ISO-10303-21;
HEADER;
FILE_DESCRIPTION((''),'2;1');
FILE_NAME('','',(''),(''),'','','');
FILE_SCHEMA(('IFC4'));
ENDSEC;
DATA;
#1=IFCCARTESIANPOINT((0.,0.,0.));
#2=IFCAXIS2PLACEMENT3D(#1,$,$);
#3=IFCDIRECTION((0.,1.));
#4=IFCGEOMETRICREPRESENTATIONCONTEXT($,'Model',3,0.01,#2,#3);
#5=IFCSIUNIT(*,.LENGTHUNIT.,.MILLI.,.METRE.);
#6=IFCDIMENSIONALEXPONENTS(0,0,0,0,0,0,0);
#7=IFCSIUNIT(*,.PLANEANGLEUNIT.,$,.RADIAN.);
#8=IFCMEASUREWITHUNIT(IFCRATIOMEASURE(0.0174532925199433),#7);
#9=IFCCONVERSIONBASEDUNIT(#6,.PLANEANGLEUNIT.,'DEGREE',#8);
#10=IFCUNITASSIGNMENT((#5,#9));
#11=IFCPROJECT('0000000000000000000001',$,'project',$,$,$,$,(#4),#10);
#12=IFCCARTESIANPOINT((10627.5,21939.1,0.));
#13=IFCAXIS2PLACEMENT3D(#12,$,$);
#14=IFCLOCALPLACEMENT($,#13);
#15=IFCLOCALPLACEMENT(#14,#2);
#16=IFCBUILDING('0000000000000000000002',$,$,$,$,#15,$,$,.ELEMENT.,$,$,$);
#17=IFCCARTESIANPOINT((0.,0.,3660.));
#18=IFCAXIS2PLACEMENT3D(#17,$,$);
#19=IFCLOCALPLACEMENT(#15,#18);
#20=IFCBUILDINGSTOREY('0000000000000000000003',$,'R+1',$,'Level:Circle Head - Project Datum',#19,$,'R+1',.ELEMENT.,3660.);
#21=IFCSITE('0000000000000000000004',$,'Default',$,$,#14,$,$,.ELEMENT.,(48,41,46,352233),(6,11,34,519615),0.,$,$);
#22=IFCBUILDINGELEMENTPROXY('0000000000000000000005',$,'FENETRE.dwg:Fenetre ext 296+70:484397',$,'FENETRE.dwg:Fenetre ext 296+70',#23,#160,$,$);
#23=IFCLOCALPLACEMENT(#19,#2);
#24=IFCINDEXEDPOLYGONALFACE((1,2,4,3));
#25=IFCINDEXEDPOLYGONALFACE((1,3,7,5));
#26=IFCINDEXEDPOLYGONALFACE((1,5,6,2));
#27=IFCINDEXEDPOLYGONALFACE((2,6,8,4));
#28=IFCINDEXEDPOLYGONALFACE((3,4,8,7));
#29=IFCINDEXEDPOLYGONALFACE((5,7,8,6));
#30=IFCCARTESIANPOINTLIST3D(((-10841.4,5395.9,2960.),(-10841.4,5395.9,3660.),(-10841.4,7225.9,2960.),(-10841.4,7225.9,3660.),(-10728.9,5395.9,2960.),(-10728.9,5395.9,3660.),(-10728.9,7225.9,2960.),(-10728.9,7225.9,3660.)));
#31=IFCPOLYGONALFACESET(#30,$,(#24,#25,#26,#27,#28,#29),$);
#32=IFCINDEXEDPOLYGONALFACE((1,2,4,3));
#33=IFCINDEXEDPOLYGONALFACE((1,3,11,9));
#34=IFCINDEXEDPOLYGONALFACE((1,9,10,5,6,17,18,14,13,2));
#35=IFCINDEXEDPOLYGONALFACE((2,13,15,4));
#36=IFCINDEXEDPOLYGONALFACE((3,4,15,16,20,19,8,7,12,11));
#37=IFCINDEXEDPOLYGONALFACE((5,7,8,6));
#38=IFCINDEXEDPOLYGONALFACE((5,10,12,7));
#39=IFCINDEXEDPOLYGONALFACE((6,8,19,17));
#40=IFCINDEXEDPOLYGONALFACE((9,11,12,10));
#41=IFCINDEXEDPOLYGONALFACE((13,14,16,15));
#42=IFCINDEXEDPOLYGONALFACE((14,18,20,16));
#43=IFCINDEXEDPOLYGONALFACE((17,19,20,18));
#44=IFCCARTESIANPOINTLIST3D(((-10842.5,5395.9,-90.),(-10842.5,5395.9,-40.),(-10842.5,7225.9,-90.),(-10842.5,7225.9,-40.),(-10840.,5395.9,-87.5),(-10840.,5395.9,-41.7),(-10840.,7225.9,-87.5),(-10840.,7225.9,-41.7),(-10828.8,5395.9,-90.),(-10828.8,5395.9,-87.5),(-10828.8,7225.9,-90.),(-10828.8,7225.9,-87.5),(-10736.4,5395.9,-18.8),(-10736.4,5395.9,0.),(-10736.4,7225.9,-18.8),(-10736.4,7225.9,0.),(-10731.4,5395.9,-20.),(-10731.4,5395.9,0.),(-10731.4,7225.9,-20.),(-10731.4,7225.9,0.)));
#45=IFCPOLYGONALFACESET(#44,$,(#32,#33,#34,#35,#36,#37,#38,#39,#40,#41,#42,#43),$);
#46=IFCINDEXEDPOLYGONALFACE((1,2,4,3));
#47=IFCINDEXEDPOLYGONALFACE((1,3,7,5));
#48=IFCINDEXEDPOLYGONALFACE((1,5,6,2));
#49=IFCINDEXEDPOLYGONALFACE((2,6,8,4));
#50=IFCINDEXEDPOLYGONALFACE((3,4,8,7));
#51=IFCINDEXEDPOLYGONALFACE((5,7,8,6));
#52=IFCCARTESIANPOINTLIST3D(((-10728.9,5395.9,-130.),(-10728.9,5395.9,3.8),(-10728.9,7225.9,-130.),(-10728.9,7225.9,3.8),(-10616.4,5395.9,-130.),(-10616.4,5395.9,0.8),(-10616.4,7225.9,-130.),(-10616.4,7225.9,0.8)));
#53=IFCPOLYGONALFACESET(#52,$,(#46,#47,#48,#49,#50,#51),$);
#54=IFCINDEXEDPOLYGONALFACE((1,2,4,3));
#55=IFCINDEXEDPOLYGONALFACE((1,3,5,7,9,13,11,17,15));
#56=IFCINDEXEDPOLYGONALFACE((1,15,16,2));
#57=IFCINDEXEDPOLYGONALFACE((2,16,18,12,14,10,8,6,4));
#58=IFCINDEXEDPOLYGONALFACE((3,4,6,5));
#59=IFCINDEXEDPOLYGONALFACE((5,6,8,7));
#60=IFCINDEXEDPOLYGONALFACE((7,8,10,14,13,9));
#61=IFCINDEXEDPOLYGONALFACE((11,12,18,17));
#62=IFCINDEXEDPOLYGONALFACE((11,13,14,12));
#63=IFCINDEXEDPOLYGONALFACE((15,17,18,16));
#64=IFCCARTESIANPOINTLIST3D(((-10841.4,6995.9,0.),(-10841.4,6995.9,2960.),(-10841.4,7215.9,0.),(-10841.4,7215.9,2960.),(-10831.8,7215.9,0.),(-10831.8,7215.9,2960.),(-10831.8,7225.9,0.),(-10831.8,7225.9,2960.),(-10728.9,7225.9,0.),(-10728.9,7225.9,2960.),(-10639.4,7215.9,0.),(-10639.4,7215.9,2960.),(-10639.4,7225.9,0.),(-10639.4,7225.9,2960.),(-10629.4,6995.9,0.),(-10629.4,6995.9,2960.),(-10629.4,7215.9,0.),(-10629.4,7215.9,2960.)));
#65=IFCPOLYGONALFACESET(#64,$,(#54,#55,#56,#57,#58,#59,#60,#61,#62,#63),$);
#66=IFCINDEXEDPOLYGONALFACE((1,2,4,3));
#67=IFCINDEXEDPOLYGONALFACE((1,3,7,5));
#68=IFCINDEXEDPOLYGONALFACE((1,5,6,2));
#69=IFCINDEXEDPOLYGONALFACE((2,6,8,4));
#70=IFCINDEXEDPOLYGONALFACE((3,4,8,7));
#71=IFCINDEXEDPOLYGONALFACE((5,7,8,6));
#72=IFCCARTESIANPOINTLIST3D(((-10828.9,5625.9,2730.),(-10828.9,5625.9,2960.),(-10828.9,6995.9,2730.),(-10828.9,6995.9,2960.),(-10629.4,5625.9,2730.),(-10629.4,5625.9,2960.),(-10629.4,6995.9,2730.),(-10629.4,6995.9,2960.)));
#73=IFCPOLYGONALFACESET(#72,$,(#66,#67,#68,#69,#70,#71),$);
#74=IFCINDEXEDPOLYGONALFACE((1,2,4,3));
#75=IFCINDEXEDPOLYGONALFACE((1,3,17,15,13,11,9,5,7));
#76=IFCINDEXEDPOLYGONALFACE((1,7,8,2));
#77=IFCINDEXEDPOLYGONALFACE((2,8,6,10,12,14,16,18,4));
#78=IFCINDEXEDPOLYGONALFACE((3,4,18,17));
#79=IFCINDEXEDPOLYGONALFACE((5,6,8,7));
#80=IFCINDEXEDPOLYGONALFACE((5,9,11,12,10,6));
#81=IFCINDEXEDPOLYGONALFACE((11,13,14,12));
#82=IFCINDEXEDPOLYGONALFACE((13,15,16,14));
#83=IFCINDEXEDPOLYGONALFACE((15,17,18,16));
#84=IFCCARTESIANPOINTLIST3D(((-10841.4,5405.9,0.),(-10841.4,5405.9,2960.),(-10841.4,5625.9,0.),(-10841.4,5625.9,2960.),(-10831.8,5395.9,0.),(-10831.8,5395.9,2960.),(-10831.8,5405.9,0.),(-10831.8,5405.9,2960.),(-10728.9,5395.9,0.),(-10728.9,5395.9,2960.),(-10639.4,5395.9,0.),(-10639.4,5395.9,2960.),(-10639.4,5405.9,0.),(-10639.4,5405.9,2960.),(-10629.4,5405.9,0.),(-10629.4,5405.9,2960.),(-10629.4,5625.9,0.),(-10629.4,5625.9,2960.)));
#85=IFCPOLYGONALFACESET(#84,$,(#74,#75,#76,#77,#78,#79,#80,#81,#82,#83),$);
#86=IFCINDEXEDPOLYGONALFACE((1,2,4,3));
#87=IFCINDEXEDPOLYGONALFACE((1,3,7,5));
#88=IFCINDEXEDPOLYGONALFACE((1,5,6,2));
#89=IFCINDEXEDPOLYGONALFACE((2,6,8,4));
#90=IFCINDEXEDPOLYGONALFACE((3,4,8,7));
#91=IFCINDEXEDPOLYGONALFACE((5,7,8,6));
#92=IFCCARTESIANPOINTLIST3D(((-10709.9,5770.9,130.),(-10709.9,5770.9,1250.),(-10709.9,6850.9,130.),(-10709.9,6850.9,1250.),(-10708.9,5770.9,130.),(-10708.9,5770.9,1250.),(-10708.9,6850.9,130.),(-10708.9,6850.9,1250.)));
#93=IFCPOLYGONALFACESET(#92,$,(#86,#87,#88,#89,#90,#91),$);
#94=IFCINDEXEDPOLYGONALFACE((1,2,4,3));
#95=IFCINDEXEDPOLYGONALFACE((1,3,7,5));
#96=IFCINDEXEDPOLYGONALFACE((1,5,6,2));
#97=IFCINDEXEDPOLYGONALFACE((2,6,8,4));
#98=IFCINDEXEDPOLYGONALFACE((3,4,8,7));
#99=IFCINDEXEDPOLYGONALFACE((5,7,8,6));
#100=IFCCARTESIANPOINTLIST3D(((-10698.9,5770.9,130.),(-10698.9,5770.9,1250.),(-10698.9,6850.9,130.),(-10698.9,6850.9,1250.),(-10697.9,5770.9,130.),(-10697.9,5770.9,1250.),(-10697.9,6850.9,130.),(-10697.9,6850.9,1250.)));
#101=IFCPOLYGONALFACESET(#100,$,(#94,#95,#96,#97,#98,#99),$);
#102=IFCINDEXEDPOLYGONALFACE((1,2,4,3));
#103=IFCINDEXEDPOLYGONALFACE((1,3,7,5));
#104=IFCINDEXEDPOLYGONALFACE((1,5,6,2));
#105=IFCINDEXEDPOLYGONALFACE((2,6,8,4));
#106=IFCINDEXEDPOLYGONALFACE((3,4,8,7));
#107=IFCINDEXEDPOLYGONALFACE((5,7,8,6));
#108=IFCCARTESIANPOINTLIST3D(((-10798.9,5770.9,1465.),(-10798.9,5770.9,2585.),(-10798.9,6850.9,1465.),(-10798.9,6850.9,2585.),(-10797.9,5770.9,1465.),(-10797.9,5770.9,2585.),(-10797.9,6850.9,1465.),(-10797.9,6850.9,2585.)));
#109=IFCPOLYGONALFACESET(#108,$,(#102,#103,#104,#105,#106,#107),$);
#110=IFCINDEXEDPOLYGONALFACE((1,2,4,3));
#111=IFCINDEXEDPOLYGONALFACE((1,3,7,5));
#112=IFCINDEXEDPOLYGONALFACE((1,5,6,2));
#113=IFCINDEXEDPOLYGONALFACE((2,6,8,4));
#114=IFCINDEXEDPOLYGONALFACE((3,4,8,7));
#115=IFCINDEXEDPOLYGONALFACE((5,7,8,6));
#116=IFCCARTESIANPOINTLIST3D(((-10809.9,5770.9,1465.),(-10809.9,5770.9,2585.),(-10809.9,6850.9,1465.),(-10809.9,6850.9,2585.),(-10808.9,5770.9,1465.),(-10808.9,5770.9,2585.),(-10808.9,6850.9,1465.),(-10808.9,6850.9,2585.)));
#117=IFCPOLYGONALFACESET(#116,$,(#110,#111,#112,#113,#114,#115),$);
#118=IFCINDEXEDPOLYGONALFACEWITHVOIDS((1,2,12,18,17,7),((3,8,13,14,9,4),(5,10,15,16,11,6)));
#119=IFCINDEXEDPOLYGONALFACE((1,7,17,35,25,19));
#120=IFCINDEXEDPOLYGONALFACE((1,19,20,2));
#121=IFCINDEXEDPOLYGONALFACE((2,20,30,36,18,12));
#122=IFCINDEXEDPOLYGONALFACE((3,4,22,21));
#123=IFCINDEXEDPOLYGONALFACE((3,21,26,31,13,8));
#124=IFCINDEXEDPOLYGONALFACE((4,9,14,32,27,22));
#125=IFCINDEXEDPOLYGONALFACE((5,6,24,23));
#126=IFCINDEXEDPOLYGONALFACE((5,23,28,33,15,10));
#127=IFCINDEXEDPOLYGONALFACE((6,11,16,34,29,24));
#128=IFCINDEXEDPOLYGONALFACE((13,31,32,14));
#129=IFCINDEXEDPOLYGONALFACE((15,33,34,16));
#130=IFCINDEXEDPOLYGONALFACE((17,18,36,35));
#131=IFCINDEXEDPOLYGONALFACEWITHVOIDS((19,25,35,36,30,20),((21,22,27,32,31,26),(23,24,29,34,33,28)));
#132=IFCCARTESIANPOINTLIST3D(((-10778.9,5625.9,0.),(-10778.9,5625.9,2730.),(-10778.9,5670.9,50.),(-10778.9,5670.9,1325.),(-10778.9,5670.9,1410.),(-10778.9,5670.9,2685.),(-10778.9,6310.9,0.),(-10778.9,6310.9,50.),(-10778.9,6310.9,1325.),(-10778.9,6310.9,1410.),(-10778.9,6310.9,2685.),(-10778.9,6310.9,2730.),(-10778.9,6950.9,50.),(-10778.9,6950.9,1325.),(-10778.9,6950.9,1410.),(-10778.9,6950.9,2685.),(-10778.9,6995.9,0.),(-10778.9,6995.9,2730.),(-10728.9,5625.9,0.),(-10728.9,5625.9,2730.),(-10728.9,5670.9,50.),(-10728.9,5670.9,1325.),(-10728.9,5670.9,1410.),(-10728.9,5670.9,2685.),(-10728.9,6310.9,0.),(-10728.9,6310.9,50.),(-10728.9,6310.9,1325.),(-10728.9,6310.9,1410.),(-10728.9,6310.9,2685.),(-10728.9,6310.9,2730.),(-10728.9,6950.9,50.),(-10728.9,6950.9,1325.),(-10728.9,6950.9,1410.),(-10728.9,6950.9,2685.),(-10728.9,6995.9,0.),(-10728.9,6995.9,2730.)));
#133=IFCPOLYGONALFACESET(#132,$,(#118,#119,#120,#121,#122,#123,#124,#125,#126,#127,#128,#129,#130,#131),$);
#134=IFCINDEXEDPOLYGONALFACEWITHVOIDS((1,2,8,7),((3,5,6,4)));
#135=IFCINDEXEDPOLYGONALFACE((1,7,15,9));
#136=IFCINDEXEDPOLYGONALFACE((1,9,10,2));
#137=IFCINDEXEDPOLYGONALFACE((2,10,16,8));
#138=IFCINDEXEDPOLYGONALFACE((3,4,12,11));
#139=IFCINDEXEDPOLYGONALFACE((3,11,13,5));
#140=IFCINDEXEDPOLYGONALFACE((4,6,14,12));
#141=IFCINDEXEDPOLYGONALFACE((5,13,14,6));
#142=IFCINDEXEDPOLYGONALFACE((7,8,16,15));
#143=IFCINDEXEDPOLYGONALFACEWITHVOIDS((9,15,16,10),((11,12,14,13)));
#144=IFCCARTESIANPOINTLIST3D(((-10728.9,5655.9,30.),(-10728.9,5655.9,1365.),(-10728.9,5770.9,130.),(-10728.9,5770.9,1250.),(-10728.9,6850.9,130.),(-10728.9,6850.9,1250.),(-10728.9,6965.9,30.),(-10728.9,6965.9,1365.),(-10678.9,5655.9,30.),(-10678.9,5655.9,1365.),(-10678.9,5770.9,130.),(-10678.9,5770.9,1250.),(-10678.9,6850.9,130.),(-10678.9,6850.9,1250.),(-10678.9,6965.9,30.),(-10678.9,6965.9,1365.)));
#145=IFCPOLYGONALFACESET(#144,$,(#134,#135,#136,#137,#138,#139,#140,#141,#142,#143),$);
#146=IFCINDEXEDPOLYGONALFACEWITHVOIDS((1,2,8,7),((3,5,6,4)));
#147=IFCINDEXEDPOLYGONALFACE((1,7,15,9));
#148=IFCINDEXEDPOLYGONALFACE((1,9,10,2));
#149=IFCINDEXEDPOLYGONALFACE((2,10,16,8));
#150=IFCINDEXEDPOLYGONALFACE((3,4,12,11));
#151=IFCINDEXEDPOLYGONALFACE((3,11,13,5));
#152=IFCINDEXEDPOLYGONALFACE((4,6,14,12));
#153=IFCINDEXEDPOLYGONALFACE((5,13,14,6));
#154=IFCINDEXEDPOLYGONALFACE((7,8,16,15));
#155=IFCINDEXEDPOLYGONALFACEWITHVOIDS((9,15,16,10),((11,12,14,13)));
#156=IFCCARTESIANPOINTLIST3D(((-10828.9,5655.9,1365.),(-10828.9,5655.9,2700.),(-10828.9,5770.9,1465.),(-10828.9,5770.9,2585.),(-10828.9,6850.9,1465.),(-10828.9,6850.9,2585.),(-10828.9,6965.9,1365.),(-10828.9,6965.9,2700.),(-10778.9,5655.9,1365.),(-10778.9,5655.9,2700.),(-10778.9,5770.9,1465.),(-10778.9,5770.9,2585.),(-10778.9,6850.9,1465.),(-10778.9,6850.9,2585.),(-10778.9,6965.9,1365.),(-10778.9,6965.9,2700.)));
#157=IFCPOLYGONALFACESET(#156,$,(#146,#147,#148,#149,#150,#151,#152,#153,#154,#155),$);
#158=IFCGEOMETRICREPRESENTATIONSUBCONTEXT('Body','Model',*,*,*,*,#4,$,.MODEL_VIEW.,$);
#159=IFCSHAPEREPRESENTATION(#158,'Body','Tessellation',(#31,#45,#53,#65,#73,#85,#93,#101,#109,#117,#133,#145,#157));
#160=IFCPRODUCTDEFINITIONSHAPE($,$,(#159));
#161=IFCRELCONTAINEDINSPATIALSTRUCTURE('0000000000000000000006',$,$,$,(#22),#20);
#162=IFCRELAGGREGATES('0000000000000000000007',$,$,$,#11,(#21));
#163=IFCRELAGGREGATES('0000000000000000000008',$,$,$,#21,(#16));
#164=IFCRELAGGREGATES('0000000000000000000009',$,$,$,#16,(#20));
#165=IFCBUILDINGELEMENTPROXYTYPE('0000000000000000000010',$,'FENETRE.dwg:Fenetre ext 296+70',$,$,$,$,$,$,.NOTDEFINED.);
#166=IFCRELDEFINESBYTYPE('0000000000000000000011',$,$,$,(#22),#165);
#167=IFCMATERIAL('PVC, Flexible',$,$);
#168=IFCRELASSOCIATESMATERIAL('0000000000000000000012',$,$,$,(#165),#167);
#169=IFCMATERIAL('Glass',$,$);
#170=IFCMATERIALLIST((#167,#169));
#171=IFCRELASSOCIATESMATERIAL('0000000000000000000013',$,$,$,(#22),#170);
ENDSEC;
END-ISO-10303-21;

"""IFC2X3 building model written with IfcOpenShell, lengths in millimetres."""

from ifc_helpers import new_model, entity, si_unit, converted_unit, direction, frame, frame_2d, origin, origin_2d_with_axis, place, context, subcontext, project, spatial, polyline, rectangle, outline, extrude, source, transform, mapped, material, material_list, type_object, type_shapes, element, save


model = new_model("IFC2X3")

# Units and contexts
model_context = context("Model", 3, precision=0.01, world=origin(), true_north=direction((0.0, 1.0)))
body_context = subcontext(model_context, "Body", "Model", "MODEL_VIEW")
ifc_project = project(units=[si_unit("LENGTHUNIT", "METRE", prefix="MILLI"), converted_unit("PLANEANGLEUNIT", "DEGREE", entity("IfcRatioMeasure", 0.0174532925199433), si_unit("PLANEANGLEUNIT", "RADIAN"), dimensions=[0, 0, 0, 0, 0, 0, 0])], contexts=[model_context])

# Site, building, storey
site_placement = place(None, frame((10627.5, 21939.1, 0.0)))
site = spatial("IfcSite", under=ifc_project, at=site_placement, Name="Default", CompositionType="ELEMENT", RefLatitude=(48, 41, 46, 352233), RefLongitude=(6, 11, 34, 519615), RefElevation=0.0)
building_placement = place(site_placement, origin())
building = spatial("IfcBuilding", under=site, at=building_placement, CompositionType="ELEMENT")
storey_placement = place(building_placement, frame((0.0, 0.0, 3660.0)))
storey = spatial("IfcBuildingStorey", under=building, at=storey_placement, Name="R+1", ObjectType="Level:Circle Head - Project Datum", LongName="R+1", CompositionType="ELEMENT", Elevation=3660.0)

# Building element proxy
ifc_material_1 = material(Name="PVC, Flexible")
ifc_material_2 = material(Name="Glass")
building_element_proxy_type_1 = type_object("IfcBuildingElementProxyType", Name="FENETRE.dwg:Fenetre ext 296+70", PredefinedType="NOTDEFINED", material=ifc_material_1)
shared_shape_1 = source(origin(), body_context, "Body", "SweptSolid", [
    extrude(rectangle(XDim=1830.0, YDim=112.5, at=origin_2d_with_axis()), frame((-10.4, 56.3, 2960.0), z_axis=(0.0, 0.0, 1.0), x_axis=(-1.0, 0.0, 0.0)), (0.0, 0.0, 1.0), 700.0),
    extrude(outline(polyline([(-68.6, -14.4), (-72.5, -34.0), (-67.6, -35.0), (-63.9, -16.6), (44.3, -16.6), (54.1, 32.5), (40.6, 35.2), (40.1, 32.7), (51.2, 30.5), (42.2, -14.4), (-68.6, -14.4)])), frame((-925.4, 66.9, -47.5), z_axis=(-1.0, 0.0, 0.0), x_axis=(0.0, 0.980599, -0.196027)), (0.0, 0.0, -1.0), 1830.0),
    extrude(outline(polyline([(-64.7, -56.3), (66.2, -56.3), (66.2, 56.3), (-67.7, 56.3), (-64.7, -56.3)])), frame((-925.4, -56.3, -63.8), z_axis=(1.0, 0.0, 0.0), x_axis=(0.0, 0.0, -1.0)), (0.0, 0.0, 1.0), 1830.0),
    extrude(outline(polyline([(-55.6, 97.0), (-55.6, -5.9), (-55.6, -95.4), (-45.6, -95.4), (-45.6, -105.4), (174.4, -105.4), (174.4, 106.6), (-45.6, 106.6), (-45.6, 97.0), (-55.6, 97.0)])), frame((849.0, 5.9, 0.0), z_axis=(0.0, 0.0, -1.0), x_axis=(-1.0, 0.0, 0.0)), (0.0, 0.0, -1.0), 2960.0),
    extrude(rectangle(XDim=199.5, YDim=1370.0, at=origin_2d_with_axis()), frame((-10.4, 0.3, 2730.0), z_axis=(0.0, 0.0, 1.0), x_axis=(0.0, 1.0, 0.0)), (0.0, 0.0, 1.0), 230.0),
    extrude(outline(polyline([(-97.0, -55.6), (5.9, -55.6), (95.4, -55.6), (95.4, -45.6), (105.4, -45.6), (105.4, 174.4), (-106.6, 174.4), (-106.6, -45.6), (-97.0, -45.6), (-97.0, -55.6)])), frame((-869.9, 5.9, 0.0), z_axis=(0.0, 0.0, 1.0), x_axis=(0.0, -1.0, 0.0)), (0.0, 0.0, 1.0), 2960.0),
    extrude(rectangle(XDim=1.0, YDim=1080.0, at=origin_2d_with_axis()), frame((-10.4, -19.5, 130.0), z_axis=(0.0, 0.0, 1.0), x_axis=(0.0, 1.0, 0.0)), (0.0, 0.0, 1.0), 1120.0),
    extrude(rectangle(XDim=1.0, YDim=1080.0, at=frame_2d((0.0, 0.0), x_axis=(1.0, 0.0))), frame((-10.4, -30.5, 130.0), z_axis=(0.0, 0.0, 1.0), x_axis=(0.0, 1.0, 0.0)), (0.0, 0.0, 1.0), 1120.0),
    extrude(rectangle(XDim=1.0, YDim=1080.0, at=frame_2d((0.0, 0.0), x_axis=(1.0, 0.0))), frame((-10.4, 69.5, 1465.0), z_axis=(0.0, 0.0, 1.0), x_axis=(0.0, 1.0, 0.0)), (0.0, 0.0, 1.0), 1120.0),
    extrude(rectangle(XDim=1.0, YDim=1080.0, at=frame_2d((0.0, 0.0), x_axis=(1.0, 0.0))), frame((-10.4, 80.5, 1465.0), z_axis=(0.0, 0.0, 1.0), x_axis=(0.0, 1.0, 0.0)), (0.0, 0.0, 1.0), 1120.0),
    extrude(outline(polyline([(-685.0, -1365.0), (0.0, -1365.0), (685.0, -1365.0), (685.0, 1365.0), (0.0, 1365.0), (-685.0, 1365.0), (-685.0, -1365.0)]), holes=[polyline([(-640.0, -1320.0), (-640.0, -45.0), (0.0, -45.0), (640.0, -45.0), (640.0, -1320.0), (0.0, -1320.0), (-640.0, -1320.0)]), polyline([(-640.0, 40.0), (-640.0, 1315.0), (0.0, 1315.0), (640.0, 1315.0), (640.0, 40.0), (0.0, 40.0), (-640.0, 40.0)])]), frame((-10.4, 0.0, 1365.0), z_axis=(0.0, 1.0, 0.0), x_axis=(1.0, 0.0, 0.0)), (0.0, 0.0, 1.0), 50.0),
    extrude(outline(polyline([(-655.0, -667.5), (655.0, -667.5), (655.0, 667.5), (-655.0, 667.5), (-655.0, -667.5)]), holes=[polyline([(-540.0, 552.5), (540.0, 552.5), (540.0, -567.5), (-540.0, -567.5), (-540.0, 552.5)])]), frame((-10.4, -50.0, 697.5), z_axis=(0.0, 1.0, 0.0), x_axis=(-1.0, 0.0, 0.0)), (0.0, 0.0, 1.0), 50.0),
    extrude(outline(polyline([(-655.0, -667.5), (655.0, -667.5), (655.0, 667.5), (-655.0, 667.5), (-655.0, -667.5)]), holes=[polyline([(-540.0, 552.5), (540.0, 552.5), (540.0, -567.5), (-540.0, -567.5), (-540.0, 552.5)])]), frame((-10.4, 50.0, 2032.5), z_axis=(0.0, 1.0, 0.0), x_axis=(-1.0, 0.0, 0.0)), (0.0, 0.0, 1.0), 50.0),
])
type_shapes(building_element_proxy_type_1, [shared_shape_1])
ifc_material_list_1 = material_list([ifc_material_1, ifc_material_2])
proxy_1_placement = place(storey_placement, frame((-10728.9, 6321.3, 0.0), z_axis=(0.0, 0.0, 1.0), x_axis=(0.0, 1.0, 0.0)))
element("IfcBuildingElementProxy", 1, at=proxy_1_placement, inside=storey, type_object=building_element_proxy_type_1, material=ifc_material_list_1, Name="FENETRE.dwg:Fenetre ext 296+70:484397", ObjectType="FENETRE.dwg:Fenetre ext 296+70", context=body_context, shape_type="MappedRepresentation", body=[
    mapped(shared_shape_1, transform((0.0, 0.0, 0.0), scale=1.0)),
])

save(model, "model.ifc")
